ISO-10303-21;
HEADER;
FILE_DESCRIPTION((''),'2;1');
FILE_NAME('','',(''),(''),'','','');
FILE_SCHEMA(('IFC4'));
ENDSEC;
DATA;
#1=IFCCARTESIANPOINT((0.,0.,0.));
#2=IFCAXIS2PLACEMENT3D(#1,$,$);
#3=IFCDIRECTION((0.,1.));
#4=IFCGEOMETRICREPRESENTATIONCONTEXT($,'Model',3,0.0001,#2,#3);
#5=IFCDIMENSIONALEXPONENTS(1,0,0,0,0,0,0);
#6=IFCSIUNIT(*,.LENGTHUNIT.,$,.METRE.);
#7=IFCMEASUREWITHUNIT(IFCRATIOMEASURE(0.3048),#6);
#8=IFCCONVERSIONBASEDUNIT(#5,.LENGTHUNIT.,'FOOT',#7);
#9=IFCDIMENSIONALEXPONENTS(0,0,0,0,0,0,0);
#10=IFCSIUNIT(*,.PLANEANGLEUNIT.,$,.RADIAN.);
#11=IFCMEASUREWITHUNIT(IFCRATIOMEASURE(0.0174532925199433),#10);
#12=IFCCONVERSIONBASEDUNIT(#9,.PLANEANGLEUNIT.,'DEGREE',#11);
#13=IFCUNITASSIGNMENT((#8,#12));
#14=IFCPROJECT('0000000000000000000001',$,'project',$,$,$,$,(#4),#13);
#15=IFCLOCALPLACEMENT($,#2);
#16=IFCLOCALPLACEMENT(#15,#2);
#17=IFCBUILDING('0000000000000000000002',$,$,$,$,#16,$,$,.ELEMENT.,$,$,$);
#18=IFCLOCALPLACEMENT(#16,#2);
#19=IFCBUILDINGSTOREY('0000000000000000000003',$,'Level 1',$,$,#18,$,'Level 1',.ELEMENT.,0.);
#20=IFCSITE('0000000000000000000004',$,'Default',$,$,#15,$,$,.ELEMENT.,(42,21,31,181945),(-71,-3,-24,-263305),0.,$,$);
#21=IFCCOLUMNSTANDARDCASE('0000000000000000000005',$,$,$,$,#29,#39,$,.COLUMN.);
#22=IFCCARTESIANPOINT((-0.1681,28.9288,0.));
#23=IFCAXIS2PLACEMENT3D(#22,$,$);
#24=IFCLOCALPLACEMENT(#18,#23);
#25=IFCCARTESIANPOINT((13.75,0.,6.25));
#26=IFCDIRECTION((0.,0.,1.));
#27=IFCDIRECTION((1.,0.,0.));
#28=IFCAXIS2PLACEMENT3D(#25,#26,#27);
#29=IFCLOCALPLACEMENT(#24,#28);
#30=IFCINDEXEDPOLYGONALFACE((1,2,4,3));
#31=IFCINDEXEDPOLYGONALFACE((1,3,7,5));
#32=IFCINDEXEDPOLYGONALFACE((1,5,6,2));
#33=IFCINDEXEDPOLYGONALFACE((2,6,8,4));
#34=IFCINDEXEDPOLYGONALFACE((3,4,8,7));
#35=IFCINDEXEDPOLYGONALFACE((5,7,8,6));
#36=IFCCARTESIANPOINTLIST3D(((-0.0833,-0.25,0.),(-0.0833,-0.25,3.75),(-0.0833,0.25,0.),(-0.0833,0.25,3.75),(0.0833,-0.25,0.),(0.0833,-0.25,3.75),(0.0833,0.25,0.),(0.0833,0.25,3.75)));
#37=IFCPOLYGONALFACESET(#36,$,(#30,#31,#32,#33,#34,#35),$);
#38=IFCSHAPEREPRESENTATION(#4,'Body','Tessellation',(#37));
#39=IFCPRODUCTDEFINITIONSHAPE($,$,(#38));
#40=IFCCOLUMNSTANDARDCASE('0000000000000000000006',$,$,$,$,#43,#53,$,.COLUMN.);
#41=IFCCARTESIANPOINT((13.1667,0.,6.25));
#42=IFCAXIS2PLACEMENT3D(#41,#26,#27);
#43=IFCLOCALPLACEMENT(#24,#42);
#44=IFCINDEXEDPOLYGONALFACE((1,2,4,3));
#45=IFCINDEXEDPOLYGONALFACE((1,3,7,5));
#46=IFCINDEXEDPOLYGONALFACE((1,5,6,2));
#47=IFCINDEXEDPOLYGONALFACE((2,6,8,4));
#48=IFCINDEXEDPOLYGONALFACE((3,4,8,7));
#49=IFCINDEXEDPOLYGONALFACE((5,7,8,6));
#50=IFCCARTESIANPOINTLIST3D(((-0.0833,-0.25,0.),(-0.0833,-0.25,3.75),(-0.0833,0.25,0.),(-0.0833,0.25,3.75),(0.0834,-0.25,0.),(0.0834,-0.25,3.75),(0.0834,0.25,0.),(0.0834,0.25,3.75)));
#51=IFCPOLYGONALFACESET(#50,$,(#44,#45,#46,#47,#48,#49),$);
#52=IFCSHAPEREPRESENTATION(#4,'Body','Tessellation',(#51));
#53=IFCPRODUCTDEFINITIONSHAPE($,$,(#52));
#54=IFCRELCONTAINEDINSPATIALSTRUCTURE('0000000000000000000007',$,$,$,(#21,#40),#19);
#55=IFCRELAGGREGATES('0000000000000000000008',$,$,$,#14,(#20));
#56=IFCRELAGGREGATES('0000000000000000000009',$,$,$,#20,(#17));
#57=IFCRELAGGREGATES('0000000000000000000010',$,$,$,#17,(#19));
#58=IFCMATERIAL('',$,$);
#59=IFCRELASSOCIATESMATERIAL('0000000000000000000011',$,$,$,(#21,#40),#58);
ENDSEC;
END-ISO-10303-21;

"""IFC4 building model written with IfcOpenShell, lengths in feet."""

from ifc_helpers import new_model, entity, si_unit, converted_unit, direction, frame, origin, place, context, project, spatial, rectangle, extrude, material, element, save


model = new_model("IFC4")

# Units and contexts
model_context = context("Model", 3, precision=0.0001, world=origin(), true_north=direction((0.0, 1.0)))
ifc_project = project(units=[converted_unit("LENGTHUNIT", "FOOT", entity("IfcRatioMeasure", 0.3048), si_unit("LENGTHUNIT", "METRE"), dimensions=[1, 0, 0, 0, 0, 0, 0]), converted_unit("PLANEANGLEUNIT", "DEGREE", entity("IfcRatioMeasure", 0.0174532925199433), si_unit("PLANEANGLEUNIT", "RADIAN"), dimensions=[0, 0, 0, 0, 0, 0, 0])], contexts=[model_context])

# Site, building, storey
site_placement = place(None, origin())
site = spatial("IfcSite", under=ifc_project, at=site_placement, Name="Default", CompositionType="ELEMENT", RefLatitude=(42, 21, 31, 181945), RefLongitude=(-71, -3, -24, -263305), RefElevation=0.0)
building_placement = place(site_placement, origin())
building = spatial("IfcBuilding", under=site, at=building_placement, CompositionType="ELEMENT")
storey_placement = place(building_placement, origin())
storey = spatial("IfcBuildingStorey", under=building, at=storey_placement, Name="Level 1", LongName="Level 1", CompositionType="ELEMENT", Elevation=0.0)

# Columns
ifc_material_1 = material(Name="")
placement = place(storey_placement, frame((-0.1681, 28.9288, 0.0)))
for number, where, z_axis, x_axis in (
    (1, (13.75, 0.0, 6.25), (0.0, 0.0, 1.0), (1.0, 0.0, 0.0)),
    (2, (13.1667, 0.0, 6.25), (0.0, 0.0, 1.0), (1.0, 0.0, 0.0)),
):
    element("IfcColumnStandardCase", number, at=place(placement, frame(where, z_axis=z_axis, x_axis=x_axis)), inside=storey, material=ifc_material_1, PredefinedType="COLUMN", context=model_context, shape_type="SweptSolid", body=[
        extrude(rectangle(XDim=0.1667, YDim=0.5), origin(), (0.0, 0.0, 1.0), 3.75),
    ])

save(model, "model.ifc")
